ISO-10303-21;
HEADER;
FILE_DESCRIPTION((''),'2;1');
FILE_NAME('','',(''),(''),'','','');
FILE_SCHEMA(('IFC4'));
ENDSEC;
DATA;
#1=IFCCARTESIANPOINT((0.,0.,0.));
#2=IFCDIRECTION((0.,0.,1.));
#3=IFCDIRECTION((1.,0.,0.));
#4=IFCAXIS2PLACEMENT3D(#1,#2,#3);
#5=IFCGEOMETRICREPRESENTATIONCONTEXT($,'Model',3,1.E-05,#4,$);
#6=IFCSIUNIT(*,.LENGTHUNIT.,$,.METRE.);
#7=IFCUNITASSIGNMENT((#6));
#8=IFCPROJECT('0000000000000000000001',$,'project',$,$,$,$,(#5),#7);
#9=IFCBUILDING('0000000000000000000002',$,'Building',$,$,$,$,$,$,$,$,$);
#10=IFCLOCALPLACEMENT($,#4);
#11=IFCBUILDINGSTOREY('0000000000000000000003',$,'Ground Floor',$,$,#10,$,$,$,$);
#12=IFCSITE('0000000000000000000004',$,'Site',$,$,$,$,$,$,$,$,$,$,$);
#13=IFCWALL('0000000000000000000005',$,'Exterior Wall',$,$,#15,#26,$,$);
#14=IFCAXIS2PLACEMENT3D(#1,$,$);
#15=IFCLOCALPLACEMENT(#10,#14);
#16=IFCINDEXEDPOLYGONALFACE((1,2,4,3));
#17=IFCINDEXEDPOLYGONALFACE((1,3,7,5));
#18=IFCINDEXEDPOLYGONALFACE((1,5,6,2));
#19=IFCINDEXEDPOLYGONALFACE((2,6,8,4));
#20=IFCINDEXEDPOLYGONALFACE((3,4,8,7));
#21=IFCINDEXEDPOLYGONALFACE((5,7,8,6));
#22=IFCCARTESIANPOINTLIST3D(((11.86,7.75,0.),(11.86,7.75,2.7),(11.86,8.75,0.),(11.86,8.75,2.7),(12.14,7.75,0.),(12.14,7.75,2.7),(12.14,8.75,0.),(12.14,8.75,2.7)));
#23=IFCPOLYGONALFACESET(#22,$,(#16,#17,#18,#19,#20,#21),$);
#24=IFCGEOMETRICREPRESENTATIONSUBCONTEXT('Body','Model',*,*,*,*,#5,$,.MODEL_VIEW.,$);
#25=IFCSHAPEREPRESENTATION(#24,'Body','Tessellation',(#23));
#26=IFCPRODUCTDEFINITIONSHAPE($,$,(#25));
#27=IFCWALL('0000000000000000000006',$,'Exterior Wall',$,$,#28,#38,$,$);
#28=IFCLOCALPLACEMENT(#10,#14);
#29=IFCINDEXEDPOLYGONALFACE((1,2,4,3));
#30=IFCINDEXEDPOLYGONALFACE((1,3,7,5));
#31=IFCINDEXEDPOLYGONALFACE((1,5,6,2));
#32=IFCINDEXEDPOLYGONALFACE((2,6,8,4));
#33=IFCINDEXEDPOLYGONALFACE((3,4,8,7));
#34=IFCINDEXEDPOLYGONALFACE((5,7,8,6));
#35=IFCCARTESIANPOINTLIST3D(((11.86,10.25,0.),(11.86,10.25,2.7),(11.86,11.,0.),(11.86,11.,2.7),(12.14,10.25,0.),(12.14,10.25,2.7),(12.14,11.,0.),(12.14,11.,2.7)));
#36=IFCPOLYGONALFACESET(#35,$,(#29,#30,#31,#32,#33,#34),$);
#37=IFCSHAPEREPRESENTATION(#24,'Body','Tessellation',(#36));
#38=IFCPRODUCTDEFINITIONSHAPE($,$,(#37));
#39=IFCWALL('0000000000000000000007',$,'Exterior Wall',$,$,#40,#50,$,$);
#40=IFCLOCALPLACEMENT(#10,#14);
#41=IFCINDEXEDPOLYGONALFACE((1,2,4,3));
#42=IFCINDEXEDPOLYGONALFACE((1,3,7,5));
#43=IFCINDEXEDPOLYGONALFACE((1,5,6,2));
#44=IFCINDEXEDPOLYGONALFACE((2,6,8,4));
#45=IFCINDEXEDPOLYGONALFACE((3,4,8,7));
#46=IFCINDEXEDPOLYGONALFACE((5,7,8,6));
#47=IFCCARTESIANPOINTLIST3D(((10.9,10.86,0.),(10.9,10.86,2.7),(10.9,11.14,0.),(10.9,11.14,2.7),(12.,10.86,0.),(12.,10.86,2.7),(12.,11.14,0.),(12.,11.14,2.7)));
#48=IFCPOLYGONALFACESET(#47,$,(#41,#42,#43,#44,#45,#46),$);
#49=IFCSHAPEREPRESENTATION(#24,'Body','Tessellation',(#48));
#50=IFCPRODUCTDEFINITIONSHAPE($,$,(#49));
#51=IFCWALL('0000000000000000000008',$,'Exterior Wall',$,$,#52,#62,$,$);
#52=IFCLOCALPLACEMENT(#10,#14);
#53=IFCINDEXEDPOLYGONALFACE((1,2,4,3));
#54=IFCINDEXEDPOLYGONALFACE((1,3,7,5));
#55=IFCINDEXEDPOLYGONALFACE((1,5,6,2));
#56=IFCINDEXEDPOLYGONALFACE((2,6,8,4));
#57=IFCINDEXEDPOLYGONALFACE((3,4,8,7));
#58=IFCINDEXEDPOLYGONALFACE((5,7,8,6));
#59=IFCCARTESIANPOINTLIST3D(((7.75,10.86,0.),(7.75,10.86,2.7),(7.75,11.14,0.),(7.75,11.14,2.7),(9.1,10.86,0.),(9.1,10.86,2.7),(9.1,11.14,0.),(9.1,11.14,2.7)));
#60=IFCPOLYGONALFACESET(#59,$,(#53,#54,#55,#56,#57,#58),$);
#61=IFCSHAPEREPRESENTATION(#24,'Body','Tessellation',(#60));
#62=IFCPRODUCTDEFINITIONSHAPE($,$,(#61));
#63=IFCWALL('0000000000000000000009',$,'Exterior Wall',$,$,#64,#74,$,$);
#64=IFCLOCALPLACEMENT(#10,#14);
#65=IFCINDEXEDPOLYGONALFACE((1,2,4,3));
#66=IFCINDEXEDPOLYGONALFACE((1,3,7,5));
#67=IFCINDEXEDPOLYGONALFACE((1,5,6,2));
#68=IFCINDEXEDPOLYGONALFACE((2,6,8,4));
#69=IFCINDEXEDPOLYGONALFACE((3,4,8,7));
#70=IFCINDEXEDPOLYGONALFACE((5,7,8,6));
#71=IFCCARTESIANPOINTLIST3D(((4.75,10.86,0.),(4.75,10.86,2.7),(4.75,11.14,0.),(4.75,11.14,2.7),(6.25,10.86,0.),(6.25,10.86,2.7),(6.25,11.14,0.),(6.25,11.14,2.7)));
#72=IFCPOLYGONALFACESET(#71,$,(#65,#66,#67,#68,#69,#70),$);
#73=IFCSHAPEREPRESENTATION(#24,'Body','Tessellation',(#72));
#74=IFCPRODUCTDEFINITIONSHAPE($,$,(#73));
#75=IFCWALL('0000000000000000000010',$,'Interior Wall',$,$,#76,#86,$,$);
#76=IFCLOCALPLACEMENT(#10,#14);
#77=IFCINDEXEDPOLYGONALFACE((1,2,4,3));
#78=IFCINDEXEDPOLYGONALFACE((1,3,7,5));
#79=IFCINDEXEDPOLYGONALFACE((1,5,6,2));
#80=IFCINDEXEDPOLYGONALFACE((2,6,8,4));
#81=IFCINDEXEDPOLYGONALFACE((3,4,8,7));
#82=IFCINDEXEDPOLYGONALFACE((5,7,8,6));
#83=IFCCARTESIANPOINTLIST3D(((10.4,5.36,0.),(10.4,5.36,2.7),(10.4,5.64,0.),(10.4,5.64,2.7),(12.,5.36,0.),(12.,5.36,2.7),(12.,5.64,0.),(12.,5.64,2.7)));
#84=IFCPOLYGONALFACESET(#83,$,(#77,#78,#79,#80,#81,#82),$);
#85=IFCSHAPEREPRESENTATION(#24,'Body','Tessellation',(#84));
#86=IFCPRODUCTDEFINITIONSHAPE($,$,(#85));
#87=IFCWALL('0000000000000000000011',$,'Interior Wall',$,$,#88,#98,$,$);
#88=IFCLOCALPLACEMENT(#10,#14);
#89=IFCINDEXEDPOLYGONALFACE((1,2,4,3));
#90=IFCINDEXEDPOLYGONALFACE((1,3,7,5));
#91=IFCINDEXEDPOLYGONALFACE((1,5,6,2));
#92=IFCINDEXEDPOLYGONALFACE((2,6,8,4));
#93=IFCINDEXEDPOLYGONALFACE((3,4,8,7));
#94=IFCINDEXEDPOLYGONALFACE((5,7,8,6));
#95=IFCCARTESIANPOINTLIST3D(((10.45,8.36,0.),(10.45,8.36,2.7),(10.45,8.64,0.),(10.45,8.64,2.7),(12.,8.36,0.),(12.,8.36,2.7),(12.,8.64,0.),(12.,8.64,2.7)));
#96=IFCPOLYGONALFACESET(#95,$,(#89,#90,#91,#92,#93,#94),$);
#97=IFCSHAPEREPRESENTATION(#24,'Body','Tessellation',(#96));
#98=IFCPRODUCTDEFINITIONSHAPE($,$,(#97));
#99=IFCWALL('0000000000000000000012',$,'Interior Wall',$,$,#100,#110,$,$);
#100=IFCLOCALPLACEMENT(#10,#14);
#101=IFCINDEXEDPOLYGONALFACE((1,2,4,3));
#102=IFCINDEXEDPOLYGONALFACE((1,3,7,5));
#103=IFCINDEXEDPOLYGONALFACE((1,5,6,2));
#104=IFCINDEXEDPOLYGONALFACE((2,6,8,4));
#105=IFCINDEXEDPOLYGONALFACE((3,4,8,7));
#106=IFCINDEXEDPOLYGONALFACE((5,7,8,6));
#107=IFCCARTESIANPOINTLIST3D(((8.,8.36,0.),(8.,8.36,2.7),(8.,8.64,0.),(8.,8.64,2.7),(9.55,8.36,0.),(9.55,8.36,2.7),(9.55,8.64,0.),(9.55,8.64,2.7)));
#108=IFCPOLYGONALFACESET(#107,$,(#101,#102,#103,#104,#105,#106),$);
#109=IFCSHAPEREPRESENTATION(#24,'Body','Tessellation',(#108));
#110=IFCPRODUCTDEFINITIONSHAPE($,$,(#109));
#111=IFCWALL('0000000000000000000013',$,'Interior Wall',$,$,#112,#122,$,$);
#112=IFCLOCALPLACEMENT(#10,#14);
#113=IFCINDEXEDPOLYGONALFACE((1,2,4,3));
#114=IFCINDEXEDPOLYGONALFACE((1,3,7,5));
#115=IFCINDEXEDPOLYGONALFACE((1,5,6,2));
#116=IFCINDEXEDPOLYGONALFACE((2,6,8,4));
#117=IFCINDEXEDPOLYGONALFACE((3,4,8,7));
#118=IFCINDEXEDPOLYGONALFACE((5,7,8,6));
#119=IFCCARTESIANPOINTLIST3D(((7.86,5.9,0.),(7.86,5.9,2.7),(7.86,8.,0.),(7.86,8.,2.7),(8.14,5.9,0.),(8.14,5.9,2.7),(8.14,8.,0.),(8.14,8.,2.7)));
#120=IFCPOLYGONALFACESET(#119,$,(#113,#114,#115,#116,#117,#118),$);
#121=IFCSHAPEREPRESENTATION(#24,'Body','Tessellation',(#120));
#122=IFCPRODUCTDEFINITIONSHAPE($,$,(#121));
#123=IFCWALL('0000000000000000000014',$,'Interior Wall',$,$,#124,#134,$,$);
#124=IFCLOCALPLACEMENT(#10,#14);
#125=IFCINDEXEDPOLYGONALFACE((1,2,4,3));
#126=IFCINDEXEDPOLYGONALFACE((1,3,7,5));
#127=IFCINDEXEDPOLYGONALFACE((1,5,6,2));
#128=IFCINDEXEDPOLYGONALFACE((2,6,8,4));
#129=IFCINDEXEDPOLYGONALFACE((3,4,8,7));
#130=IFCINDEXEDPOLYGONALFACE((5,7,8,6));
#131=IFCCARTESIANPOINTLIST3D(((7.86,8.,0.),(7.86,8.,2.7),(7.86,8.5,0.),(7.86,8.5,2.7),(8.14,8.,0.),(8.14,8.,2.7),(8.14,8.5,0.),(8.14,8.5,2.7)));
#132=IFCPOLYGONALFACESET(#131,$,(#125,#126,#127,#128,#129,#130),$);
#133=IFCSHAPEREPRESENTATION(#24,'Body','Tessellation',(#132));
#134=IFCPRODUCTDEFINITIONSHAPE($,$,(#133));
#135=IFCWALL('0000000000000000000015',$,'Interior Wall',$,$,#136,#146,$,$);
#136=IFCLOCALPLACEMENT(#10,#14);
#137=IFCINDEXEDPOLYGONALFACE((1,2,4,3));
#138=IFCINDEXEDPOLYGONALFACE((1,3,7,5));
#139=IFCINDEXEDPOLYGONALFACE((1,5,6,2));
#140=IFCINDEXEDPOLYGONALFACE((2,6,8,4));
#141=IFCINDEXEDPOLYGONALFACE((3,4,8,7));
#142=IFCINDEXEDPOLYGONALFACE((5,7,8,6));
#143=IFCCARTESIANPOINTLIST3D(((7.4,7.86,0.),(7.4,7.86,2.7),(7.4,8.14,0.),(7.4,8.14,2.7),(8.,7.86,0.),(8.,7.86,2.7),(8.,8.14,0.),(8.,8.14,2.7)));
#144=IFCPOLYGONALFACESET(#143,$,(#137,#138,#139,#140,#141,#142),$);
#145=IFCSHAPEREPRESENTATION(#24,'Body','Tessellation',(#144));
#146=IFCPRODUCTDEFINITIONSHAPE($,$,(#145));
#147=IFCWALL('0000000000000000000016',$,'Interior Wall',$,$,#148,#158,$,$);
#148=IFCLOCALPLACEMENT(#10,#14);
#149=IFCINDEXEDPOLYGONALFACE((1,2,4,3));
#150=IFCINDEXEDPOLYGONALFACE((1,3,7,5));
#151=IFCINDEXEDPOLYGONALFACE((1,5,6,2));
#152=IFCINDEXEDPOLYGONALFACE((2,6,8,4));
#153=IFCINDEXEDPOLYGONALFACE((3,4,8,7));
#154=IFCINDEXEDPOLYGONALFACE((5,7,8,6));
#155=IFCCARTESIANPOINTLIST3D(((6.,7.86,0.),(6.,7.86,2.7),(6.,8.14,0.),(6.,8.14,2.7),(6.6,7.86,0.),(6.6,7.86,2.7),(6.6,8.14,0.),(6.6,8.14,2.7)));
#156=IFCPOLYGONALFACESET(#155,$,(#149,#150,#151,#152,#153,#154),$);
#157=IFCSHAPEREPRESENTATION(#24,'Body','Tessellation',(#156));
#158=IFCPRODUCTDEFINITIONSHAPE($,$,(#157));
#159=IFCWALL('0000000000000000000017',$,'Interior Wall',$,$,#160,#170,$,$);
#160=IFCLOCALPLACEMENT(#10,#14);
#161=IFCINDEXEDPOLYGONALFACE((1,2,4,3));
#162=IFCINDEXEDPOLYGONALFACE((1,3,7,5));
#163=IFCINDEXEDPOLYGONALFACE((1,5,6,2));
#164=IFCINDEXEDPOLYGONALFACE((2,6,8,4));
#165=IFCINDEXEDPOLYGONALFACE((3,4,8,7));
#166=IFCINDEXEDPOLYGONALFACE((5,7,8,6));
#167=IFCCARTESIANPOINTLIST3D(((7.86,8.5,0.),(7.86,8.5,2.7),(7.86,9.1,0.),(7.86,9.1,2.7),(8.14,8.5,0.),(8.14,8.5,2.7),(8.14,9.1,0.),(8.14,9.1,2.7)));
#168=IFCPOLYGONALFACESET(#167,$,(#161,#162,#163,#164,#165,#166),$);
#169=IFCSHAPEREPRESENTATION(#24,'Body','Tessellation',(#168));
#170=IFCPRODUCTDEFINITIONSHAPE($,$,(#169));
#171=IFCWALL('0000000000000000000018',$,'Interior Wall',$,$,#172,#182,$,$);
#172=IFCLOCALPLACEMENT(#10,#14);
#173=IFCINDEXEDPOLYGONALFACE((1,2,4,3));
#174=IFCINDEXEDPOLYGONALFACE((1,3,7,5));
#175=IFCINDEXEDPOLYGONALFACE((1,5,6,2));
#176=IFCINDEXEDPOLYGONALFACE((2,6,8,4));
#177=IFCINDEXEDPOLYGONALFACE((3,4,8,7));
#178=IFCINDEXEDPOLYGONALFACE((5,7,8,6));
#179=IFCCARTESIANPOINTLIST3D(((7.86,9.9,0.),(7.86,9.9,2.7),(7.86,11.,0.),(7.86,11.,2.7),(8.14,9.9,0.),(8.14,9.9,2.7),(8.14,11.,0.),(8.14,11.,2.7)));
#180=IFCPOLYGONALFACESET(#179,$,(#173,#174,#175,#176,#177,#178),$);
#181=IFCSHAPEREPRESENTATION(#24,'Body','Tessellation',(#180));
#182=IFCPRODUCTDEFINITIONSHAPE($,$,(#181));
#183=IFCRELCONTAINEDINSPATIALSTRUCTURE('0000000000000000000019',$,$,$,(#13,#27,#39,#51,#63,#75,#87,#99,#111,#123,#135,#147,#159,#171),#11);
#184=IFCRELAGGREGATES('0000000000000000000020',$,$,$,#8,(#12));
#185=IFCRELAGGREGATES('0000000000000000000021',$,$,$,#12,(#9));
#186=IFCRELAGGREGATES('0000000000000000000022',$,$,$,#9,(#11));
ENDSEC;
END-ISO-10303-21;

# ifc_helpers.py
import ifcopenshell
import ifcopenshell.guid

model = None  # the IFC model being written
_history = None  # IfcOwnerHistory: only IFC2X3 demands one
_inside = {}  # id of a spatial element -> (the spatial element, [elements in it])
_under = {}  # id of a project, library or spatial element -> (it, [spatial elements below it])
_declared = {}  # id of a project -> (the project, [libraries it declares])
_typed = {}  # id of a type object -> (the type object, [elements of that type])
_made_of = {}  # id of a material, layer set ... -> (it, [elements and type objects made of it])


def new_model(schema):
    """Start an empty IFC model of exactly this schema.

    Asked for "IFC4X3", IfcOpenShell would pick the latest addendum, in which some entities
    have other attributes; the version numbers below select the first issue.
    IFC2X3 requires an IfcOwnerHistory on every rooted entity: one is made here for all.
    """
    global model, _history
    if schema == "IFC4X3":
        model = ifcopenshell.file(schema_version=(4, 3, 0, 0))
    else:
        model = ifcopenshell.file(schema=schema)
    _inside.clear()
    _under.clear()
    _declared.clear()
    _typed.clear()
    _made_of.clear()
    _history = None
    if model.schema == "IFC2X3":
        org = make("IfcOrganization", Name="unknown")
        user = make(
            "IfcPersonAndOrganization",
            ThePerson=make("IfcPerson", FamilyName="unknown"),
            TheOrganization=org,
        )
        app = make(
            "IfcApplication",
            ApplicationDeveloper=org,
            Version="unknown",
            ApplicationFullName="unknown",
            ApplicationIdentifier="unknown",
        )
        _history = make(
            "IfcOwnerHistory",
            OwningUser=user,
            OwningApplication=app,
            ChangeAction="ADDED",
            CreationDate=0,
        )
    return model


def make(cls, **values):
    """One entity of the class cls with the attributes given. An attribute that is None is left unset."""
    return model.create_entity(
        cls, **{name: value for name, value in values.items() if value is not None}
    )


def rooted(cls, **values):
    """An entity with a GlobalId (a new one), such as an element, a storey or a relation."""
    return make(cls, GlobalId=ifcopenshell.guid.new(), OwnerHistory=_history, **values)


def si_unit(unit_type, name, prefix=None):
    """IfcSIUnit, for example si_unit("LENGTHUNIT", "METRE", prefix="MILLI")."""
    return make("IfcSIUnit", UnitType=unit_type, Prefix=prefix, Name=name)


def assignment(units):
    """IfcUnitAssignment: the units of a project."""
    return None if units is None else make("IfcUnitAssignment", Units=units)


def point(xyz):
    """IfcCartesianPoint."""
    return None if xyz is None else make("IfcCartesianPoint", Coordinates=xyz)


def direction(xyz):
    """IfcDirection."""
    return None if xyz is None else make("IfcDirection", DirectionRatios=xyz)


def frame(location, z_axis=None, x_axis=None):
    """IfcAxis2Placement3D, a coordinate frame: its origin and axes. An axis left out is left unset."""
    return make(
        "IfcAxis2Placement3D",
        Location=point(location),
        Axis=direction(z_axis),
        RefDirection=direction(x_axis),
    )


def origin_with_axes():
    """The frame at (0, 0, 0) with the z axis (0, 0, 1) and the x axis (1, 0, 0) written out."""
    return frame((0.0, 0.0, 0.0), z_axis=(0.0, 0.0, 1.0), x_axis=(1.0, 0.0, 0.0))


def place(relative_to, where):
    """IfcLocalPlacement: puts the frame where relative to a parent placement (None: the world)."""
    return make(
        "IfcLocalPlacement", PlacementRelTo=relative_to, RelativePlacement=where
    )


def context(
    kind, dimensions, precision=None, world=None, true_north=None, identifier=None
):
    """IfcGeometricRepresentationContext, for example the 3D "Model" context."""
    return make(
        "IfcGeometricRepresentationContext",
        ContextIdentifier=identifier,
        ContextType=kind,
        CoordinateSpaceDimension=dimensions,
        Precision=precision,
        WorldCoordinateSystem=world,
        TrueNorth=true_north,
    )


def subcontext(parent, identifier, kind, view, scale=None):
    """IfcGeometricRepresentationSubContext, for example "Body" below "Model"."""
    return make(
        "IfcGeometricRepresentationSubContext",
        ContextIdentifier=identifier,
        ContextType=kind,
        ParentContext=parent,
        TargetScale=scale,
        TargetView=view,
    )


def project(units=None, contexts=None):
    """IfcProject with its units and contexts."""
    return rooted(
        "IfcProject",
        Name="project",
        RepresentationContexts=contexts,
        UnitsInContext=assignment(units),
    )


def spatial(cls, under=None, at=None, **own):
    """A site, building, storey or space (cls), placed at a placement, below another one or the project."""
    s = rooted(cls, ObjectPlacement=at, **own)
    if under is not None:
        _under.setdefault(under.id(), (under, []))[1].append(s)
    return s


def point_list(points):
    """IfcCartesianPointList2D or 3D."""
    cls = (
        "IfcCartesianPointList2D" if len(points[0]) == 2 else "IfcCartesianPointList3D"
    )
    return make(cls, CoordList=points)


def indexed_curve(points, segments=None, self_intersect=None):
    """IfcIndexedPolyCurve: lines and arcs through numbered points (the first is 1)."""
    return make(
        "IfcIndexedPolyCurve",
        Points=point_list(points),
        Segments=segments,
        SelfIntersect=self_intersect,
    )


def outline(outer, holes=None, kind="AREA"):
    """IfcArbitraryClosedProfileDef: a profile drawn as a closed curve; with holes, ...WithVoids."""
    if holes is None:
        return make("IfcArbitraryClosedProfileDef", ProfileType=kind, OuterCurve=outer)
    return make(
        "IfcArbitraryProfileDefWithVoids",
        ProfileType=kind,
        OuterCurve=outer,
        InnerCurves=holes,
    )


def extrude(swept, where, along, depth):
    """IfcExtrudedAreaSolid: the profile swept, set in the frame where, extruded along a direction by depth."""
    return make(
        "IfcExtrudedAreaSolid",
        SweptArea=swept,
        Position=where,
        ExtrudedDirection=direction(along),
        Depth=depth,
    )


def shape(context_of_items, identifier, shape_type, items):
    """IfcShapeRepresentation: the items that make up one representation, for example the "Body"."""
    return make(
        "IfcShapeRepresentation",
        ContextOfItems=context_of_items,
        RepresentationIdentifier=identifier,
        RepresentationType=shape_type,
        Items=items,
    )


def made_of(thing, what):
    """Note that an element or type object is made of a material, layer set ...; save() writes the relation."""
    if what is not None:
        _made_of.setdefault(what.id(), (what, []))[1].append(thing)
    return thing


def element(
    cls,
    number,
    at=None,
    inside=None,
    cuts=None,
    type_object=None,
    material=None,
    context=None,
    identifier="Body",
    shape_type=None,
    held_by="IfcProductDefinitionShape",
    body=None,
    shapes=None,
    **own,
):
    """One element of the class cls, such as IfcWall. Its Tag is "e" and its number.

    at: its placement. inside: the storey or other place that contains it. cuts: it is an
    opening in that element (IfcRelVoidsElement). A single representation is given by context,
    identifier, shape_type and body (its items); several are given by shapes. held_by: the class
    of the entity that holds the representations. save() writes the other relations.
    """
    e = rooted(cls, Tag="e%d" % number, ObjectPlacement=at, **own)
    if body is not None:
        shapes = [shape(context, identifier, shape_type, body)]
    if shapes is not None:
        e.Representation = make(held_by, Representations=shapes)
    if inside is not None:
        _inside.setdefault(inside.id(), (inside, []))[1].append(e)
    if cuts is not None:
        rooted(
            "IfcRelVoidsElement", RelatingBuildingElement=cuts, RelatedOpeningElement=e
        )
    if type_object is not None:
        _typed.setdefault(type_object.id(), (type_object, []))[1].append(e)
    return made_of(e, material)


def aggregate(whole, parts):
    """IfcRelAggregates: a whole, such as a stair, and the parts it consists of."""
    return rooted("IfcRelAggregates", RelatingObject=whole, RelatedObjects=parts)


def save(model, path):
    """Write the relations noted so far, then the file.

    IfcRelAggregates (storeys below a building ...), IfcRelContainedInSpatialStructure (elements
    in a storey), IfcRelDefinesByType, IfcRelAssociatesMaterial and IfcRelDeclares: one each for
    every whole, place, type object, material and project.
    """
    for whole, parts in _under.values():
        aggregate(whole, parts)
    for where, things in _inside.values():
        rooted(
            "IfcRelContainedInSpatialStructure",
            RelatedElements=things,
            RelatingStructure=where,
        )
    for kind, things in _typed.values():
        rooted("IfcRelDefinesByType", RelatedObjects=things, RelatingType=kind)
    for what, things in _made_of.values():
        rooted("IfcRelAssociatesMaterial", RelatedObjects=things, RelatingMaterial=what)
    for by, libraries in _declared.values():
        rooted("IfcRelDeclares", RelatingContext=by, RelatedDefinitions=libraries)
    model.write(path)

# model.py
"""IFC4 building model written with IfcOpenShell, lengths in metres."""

from ifc_helpers import new_model, si_unit, frame, origin_with_axes, place, context, subcontext, project, spatial, indexed_curve, outline, extrude, element, save


model = new_model("IFC4")

# Units and contexts
model_context = context("Model", 3, precision=1e-05, world=origin_with_axes())
body_context = subcontext(model_context, "Body", "Model", "MODEL_VIEW")
ifc_project = project(units=[si_unit("LENGTHUNIT", "METRE")], contexts=[model_context])

# Site, building, storey
site = spatial("IfcSite", under=ifc_project, Name="Site")
building = spatial("IfcBuilding", under=site, Name="Building")
storey_placement = place(None, origin_with_axes())
storey = spatial("IfcBuildingStorey", under=building, at=storey_placement, Name="Ground Floor")

# Walls
wall_1_placement = place(storey_placement, frame((12.0, 7.75, 0.0), z_axis=(0.0, 0.0, 1.0), x_axis=(0.0, 1.0, 0.0)))
element("IfcWall", 1, at=wall_1_placement, inside=storey, Name="Exterior Wall", context=body_context, shape_type="SweptSolid", body=[
    extrude(outline(indexed_curve([(0.0, 0.0), (0.0, 0.28), (1.0, 0.28), (1.0, 0.0), (0.0, 0.0)], self_intersect=False)), frame((0.0, -0.14, 0.0), z_axis=(0.0, 0.0, 1.0), x_axis=(1.0, 0.0, 0.0)), (0.0, 0.0, 1.0), 2.7),
])
wall_2_placement = place(storey_placement, frame((12.0, 10.25, 0.0), z_axis=(0.0, 0.0, 1.0), x_axis=(0.0, 1.0, 0.0)))
element("IfcWall", 2, at=wall_2_placement, inside=storey, Name="Exterior Wall", context=body_context, shape_type="SweptSolid", body=[
    extrude(outline(indexed_curve([(0.0, 0.0), (0.0, 0.28), (0.75, 0.28), (0.75, 0.0), (0.0, 0.0)], self_intersect=False)), frame((0.0, -0.14, 0.0), z_axis=(0.0, 0.0, 1.0), x_axis=(1.0, 0.0, 0.0)), (0.0, 0.0, 1.0), 2.7),
])
wall_3_placement = place(storey_placement, frame((12.0, 11.0, 0.0), z_axis=(0.0, 0.0, 1.0), x_axis=(-1.0, 0.0, 0.0)))
element("IfcWall", 3, at=wall_3_placement, inside=storey, Name="Exterior Wall", context=body_context, shape_type="SweptSolid", body=[
    extrude(outline(indexed_curve([(0.0, 0.0), (0.0, 0.28), (1.1, 0.28), (1.1, 0.0), (0.0, 0.0)], self_intersect=False)), frame((0.0, -0.14, 0.0), z_axis=(0.0, 0.0, 1.0), x_axis=(1.0, 0.0, 0.0)), (0.0, 0.0, 1.0), 2.7),
])
wall_4_placement = place(storey_placement, frame((9.1, 11.0, 0.0), z_axis=(0.0, 0.0, 1.0), x_axis=(-1.0, 0.0, 0.0)))
element("IfcWall", 4, at=wall_4_placement, inside=storey, Name="Exterior Wall", context=body_context, shape_type="SweptSolid", body=[
    extrude(outline(indexed_curve([(0.0, 0.0), (0.0, 0.28), (1.35, 0.28), (1.35, 0.0), (0.0, 0.0)], self_intersect=False)), frame((0.0, -0.14, 0.0), z_axis=(0.0, 0.0, 1.0), x_axis=(1.0, 0.0, 0.0)), (0.0, 0.0, 1.0), 2.7),
])
wall_5_placement = place(storey_placement, frame((6.25, 11.0, 0.0), z_axis=(0.0, 0.0, 1.0), x_axis=(-1.0, 0.0, 0.0)))
element("IfcWall", 5, at=wall_5_placement, inside=storey, Name="Exterior Wall", context=body_context, shape_type="SweptSolid", body=[
    extrude(outline(indexed_curve([(0.0, 0.0), (0.0, 0.28), (1.5, 0.28), (1.5, 0.0), (0.0, 0.0)], self_intersect=False)), frame((0.0, -0.14, 0.0), z_axis=(0.0, 0.0, 1.0), x_axis=(1.0, 0.0, 0.0)), (0.0, 0.0, 1.0), 2.7),
])
wall_6_placement = place(storey_placement, frame((12.0, 5.5, 0.0), z_axis=(0.0, 0.0, 1.0), x_axis=(-1.0, 0.0, 0.0)))
element("IfcWall", 6, at=wall_6_placement, inside=storey, Name="Interior Wall", context=body_context, shape_type="SweptSolid", body=[
    extrude(outline(indexed_curve([(0.0, 0.0), (0.0, 0.28), (1.6, 0.28), (1.6, 0.0), (0.0, 0.0)], self_intersect=False)), frame((0.0, -0.14, 0.0), z_axis=(0.0, 0.0, 1.0), x_axis=(1.0, 0.0, 0.0)), (0.0, 0.0, 1.0), 2.7),
])
for number, where, z_axis, x_axis, name in (
    (7, (12.0, 8.5, 0.0), (0.0, 0.0, 1.0), (-1.0, 0.0, 0.0), "Interior Wall"),
    (8, (9.55, 8.5, 0.0), (0.0, 0.0, 1.0), (-1.0, 0.0, 0.0), "Interior Wall"),
):
    element("IfcWall", number, at=place(storey_placement, frame(where, z_axis=z_axis, x_axis=x_axis)), inside=storey, Name=name, context=body_context, shape_type="SweptSolid", body=[
        extrude(outline(indexed_curve([(0.0, 0.0), (0.0, 0.28), (1.55, 0.28), (1.55, 0.0), (0.0, 0.0)], self_intersect=False)), frame((0.0, -0.14, 0.0), z_axis=(0.0, 0.0, 1.0), x_axis=(1.0, 0.0, 0.0)), (0.0, 0.0, 1.0), 2.7),
    ])
wall_7_placement = place(storey_placement, frame((8.0, 8.0, 0.0), z_axis=(0.0, 0.0, 1.0), x_axis=(0.0, -1.0, 0.0)))
element("IfcWall", 9, at=wall_7_placement, inside=storey, Name="Interior Wall", context=body_context, shape_type="SweptSolid", body=[
    extrude(outline(indexed_curve([(0.0, 0.0), (0.0, 0.28), (2.1, 0.28), (2.1, 0.0), (0.0, 0.0)], self_intersect=False)), frame((0.0, -0.14, 0.0), z_axis=(0.0, 0.0, 1.0), x_axis=(1.0, 0.0, 0.0)), (0.0, 0.0, 1.0), 2.7),
])
wall_8_placement = place(storey_placement, frame((8.0, 8.5, 0.0), z_axis=(0.0, 0.0, 1.0), x_axis=(0.0, -1.0, 0.0)))
element("IfcWall", 10, at=wall_8_placement, inside=storey, Name="Interior Wall", context=body_context, shape_type="SweptSolid", body=[
    extrude(outline(indexed_curve([(0.0, 0.0), (0.0, 0.28), (0.5, 0.28), (0.5, 0.0), (0.0, 0.0)], self_intersect=False)), frame((0.0, -0.14, 0.0), z_axis=(0.0, 0.0, 1.0), x_axis=(1.0, 0.0, 0.0)), (0.0, 0.0, 1.0), 2.7),
])
for number, where, z_axis, x_axis, name in (
    (11, (8.0, 8.0, 0.0), (0.0, 0.0, 1.0), (-1.0, 0.0, 0.0), "Interior Wall"),
    (12, (6.6, 8.0, 0.0), (0.0, 0.0, 1.0), (-1.0, 0.0, 0.0), "Interior Wall"),
    (13, (8.0, 8.5, 0.0), (0.0, 0.0, 1.0), (0.0, 1.0, 0.0), "Interior Wall"),
):
    element("IfcWall", number, at=place(storey_placement, frame(where, z_axis=z_axis, x_axis=x_axis)), inside=storey, Name=name, context=body_context, shape_type="SweptSolid", body=[
        extrude(outline(indexed_curve([(0.0, 0.0), (0.0, 0.28), (0.6, 0.28), (0.6, 0.0), (0.0, 0.0)], self_intersect=False)), frame((0.0, -0.14, 0.0), z_axis=(0.0, 0.0, 1.0), x_axis=(1.0, 0.0, 0.0)), (0.0, 0.0, 1.0), 2.7),
    ])
wall_9_placement = place(storey_placement, frame((8.0, 9.9, 0.0), z_axis=(0.0, 0.0, 1.0), x_axis=(0.0, 1.0, 0.0)))
element("IfcWall", 14, at=wall_9_placement, inside=storey, Name="Interior Wall", context=body_context, shape_type="SweptSolid", body=[
    extrude(outline(indexed_curve([(0.0, 0.0), (0.0, 0.28), (1.1, 0.28), (1.1, 0.0), (0.0, 0.0)], self_intersect=False)), frame((0.0, -0.14, 0.0), z_axis=(0.0, 0.0, 1.0), x_axis=(1.0, 0.0, 0.0)), (0.0, 0.0, 1.0), 2.7),
])

save(model, "model.ifc")
